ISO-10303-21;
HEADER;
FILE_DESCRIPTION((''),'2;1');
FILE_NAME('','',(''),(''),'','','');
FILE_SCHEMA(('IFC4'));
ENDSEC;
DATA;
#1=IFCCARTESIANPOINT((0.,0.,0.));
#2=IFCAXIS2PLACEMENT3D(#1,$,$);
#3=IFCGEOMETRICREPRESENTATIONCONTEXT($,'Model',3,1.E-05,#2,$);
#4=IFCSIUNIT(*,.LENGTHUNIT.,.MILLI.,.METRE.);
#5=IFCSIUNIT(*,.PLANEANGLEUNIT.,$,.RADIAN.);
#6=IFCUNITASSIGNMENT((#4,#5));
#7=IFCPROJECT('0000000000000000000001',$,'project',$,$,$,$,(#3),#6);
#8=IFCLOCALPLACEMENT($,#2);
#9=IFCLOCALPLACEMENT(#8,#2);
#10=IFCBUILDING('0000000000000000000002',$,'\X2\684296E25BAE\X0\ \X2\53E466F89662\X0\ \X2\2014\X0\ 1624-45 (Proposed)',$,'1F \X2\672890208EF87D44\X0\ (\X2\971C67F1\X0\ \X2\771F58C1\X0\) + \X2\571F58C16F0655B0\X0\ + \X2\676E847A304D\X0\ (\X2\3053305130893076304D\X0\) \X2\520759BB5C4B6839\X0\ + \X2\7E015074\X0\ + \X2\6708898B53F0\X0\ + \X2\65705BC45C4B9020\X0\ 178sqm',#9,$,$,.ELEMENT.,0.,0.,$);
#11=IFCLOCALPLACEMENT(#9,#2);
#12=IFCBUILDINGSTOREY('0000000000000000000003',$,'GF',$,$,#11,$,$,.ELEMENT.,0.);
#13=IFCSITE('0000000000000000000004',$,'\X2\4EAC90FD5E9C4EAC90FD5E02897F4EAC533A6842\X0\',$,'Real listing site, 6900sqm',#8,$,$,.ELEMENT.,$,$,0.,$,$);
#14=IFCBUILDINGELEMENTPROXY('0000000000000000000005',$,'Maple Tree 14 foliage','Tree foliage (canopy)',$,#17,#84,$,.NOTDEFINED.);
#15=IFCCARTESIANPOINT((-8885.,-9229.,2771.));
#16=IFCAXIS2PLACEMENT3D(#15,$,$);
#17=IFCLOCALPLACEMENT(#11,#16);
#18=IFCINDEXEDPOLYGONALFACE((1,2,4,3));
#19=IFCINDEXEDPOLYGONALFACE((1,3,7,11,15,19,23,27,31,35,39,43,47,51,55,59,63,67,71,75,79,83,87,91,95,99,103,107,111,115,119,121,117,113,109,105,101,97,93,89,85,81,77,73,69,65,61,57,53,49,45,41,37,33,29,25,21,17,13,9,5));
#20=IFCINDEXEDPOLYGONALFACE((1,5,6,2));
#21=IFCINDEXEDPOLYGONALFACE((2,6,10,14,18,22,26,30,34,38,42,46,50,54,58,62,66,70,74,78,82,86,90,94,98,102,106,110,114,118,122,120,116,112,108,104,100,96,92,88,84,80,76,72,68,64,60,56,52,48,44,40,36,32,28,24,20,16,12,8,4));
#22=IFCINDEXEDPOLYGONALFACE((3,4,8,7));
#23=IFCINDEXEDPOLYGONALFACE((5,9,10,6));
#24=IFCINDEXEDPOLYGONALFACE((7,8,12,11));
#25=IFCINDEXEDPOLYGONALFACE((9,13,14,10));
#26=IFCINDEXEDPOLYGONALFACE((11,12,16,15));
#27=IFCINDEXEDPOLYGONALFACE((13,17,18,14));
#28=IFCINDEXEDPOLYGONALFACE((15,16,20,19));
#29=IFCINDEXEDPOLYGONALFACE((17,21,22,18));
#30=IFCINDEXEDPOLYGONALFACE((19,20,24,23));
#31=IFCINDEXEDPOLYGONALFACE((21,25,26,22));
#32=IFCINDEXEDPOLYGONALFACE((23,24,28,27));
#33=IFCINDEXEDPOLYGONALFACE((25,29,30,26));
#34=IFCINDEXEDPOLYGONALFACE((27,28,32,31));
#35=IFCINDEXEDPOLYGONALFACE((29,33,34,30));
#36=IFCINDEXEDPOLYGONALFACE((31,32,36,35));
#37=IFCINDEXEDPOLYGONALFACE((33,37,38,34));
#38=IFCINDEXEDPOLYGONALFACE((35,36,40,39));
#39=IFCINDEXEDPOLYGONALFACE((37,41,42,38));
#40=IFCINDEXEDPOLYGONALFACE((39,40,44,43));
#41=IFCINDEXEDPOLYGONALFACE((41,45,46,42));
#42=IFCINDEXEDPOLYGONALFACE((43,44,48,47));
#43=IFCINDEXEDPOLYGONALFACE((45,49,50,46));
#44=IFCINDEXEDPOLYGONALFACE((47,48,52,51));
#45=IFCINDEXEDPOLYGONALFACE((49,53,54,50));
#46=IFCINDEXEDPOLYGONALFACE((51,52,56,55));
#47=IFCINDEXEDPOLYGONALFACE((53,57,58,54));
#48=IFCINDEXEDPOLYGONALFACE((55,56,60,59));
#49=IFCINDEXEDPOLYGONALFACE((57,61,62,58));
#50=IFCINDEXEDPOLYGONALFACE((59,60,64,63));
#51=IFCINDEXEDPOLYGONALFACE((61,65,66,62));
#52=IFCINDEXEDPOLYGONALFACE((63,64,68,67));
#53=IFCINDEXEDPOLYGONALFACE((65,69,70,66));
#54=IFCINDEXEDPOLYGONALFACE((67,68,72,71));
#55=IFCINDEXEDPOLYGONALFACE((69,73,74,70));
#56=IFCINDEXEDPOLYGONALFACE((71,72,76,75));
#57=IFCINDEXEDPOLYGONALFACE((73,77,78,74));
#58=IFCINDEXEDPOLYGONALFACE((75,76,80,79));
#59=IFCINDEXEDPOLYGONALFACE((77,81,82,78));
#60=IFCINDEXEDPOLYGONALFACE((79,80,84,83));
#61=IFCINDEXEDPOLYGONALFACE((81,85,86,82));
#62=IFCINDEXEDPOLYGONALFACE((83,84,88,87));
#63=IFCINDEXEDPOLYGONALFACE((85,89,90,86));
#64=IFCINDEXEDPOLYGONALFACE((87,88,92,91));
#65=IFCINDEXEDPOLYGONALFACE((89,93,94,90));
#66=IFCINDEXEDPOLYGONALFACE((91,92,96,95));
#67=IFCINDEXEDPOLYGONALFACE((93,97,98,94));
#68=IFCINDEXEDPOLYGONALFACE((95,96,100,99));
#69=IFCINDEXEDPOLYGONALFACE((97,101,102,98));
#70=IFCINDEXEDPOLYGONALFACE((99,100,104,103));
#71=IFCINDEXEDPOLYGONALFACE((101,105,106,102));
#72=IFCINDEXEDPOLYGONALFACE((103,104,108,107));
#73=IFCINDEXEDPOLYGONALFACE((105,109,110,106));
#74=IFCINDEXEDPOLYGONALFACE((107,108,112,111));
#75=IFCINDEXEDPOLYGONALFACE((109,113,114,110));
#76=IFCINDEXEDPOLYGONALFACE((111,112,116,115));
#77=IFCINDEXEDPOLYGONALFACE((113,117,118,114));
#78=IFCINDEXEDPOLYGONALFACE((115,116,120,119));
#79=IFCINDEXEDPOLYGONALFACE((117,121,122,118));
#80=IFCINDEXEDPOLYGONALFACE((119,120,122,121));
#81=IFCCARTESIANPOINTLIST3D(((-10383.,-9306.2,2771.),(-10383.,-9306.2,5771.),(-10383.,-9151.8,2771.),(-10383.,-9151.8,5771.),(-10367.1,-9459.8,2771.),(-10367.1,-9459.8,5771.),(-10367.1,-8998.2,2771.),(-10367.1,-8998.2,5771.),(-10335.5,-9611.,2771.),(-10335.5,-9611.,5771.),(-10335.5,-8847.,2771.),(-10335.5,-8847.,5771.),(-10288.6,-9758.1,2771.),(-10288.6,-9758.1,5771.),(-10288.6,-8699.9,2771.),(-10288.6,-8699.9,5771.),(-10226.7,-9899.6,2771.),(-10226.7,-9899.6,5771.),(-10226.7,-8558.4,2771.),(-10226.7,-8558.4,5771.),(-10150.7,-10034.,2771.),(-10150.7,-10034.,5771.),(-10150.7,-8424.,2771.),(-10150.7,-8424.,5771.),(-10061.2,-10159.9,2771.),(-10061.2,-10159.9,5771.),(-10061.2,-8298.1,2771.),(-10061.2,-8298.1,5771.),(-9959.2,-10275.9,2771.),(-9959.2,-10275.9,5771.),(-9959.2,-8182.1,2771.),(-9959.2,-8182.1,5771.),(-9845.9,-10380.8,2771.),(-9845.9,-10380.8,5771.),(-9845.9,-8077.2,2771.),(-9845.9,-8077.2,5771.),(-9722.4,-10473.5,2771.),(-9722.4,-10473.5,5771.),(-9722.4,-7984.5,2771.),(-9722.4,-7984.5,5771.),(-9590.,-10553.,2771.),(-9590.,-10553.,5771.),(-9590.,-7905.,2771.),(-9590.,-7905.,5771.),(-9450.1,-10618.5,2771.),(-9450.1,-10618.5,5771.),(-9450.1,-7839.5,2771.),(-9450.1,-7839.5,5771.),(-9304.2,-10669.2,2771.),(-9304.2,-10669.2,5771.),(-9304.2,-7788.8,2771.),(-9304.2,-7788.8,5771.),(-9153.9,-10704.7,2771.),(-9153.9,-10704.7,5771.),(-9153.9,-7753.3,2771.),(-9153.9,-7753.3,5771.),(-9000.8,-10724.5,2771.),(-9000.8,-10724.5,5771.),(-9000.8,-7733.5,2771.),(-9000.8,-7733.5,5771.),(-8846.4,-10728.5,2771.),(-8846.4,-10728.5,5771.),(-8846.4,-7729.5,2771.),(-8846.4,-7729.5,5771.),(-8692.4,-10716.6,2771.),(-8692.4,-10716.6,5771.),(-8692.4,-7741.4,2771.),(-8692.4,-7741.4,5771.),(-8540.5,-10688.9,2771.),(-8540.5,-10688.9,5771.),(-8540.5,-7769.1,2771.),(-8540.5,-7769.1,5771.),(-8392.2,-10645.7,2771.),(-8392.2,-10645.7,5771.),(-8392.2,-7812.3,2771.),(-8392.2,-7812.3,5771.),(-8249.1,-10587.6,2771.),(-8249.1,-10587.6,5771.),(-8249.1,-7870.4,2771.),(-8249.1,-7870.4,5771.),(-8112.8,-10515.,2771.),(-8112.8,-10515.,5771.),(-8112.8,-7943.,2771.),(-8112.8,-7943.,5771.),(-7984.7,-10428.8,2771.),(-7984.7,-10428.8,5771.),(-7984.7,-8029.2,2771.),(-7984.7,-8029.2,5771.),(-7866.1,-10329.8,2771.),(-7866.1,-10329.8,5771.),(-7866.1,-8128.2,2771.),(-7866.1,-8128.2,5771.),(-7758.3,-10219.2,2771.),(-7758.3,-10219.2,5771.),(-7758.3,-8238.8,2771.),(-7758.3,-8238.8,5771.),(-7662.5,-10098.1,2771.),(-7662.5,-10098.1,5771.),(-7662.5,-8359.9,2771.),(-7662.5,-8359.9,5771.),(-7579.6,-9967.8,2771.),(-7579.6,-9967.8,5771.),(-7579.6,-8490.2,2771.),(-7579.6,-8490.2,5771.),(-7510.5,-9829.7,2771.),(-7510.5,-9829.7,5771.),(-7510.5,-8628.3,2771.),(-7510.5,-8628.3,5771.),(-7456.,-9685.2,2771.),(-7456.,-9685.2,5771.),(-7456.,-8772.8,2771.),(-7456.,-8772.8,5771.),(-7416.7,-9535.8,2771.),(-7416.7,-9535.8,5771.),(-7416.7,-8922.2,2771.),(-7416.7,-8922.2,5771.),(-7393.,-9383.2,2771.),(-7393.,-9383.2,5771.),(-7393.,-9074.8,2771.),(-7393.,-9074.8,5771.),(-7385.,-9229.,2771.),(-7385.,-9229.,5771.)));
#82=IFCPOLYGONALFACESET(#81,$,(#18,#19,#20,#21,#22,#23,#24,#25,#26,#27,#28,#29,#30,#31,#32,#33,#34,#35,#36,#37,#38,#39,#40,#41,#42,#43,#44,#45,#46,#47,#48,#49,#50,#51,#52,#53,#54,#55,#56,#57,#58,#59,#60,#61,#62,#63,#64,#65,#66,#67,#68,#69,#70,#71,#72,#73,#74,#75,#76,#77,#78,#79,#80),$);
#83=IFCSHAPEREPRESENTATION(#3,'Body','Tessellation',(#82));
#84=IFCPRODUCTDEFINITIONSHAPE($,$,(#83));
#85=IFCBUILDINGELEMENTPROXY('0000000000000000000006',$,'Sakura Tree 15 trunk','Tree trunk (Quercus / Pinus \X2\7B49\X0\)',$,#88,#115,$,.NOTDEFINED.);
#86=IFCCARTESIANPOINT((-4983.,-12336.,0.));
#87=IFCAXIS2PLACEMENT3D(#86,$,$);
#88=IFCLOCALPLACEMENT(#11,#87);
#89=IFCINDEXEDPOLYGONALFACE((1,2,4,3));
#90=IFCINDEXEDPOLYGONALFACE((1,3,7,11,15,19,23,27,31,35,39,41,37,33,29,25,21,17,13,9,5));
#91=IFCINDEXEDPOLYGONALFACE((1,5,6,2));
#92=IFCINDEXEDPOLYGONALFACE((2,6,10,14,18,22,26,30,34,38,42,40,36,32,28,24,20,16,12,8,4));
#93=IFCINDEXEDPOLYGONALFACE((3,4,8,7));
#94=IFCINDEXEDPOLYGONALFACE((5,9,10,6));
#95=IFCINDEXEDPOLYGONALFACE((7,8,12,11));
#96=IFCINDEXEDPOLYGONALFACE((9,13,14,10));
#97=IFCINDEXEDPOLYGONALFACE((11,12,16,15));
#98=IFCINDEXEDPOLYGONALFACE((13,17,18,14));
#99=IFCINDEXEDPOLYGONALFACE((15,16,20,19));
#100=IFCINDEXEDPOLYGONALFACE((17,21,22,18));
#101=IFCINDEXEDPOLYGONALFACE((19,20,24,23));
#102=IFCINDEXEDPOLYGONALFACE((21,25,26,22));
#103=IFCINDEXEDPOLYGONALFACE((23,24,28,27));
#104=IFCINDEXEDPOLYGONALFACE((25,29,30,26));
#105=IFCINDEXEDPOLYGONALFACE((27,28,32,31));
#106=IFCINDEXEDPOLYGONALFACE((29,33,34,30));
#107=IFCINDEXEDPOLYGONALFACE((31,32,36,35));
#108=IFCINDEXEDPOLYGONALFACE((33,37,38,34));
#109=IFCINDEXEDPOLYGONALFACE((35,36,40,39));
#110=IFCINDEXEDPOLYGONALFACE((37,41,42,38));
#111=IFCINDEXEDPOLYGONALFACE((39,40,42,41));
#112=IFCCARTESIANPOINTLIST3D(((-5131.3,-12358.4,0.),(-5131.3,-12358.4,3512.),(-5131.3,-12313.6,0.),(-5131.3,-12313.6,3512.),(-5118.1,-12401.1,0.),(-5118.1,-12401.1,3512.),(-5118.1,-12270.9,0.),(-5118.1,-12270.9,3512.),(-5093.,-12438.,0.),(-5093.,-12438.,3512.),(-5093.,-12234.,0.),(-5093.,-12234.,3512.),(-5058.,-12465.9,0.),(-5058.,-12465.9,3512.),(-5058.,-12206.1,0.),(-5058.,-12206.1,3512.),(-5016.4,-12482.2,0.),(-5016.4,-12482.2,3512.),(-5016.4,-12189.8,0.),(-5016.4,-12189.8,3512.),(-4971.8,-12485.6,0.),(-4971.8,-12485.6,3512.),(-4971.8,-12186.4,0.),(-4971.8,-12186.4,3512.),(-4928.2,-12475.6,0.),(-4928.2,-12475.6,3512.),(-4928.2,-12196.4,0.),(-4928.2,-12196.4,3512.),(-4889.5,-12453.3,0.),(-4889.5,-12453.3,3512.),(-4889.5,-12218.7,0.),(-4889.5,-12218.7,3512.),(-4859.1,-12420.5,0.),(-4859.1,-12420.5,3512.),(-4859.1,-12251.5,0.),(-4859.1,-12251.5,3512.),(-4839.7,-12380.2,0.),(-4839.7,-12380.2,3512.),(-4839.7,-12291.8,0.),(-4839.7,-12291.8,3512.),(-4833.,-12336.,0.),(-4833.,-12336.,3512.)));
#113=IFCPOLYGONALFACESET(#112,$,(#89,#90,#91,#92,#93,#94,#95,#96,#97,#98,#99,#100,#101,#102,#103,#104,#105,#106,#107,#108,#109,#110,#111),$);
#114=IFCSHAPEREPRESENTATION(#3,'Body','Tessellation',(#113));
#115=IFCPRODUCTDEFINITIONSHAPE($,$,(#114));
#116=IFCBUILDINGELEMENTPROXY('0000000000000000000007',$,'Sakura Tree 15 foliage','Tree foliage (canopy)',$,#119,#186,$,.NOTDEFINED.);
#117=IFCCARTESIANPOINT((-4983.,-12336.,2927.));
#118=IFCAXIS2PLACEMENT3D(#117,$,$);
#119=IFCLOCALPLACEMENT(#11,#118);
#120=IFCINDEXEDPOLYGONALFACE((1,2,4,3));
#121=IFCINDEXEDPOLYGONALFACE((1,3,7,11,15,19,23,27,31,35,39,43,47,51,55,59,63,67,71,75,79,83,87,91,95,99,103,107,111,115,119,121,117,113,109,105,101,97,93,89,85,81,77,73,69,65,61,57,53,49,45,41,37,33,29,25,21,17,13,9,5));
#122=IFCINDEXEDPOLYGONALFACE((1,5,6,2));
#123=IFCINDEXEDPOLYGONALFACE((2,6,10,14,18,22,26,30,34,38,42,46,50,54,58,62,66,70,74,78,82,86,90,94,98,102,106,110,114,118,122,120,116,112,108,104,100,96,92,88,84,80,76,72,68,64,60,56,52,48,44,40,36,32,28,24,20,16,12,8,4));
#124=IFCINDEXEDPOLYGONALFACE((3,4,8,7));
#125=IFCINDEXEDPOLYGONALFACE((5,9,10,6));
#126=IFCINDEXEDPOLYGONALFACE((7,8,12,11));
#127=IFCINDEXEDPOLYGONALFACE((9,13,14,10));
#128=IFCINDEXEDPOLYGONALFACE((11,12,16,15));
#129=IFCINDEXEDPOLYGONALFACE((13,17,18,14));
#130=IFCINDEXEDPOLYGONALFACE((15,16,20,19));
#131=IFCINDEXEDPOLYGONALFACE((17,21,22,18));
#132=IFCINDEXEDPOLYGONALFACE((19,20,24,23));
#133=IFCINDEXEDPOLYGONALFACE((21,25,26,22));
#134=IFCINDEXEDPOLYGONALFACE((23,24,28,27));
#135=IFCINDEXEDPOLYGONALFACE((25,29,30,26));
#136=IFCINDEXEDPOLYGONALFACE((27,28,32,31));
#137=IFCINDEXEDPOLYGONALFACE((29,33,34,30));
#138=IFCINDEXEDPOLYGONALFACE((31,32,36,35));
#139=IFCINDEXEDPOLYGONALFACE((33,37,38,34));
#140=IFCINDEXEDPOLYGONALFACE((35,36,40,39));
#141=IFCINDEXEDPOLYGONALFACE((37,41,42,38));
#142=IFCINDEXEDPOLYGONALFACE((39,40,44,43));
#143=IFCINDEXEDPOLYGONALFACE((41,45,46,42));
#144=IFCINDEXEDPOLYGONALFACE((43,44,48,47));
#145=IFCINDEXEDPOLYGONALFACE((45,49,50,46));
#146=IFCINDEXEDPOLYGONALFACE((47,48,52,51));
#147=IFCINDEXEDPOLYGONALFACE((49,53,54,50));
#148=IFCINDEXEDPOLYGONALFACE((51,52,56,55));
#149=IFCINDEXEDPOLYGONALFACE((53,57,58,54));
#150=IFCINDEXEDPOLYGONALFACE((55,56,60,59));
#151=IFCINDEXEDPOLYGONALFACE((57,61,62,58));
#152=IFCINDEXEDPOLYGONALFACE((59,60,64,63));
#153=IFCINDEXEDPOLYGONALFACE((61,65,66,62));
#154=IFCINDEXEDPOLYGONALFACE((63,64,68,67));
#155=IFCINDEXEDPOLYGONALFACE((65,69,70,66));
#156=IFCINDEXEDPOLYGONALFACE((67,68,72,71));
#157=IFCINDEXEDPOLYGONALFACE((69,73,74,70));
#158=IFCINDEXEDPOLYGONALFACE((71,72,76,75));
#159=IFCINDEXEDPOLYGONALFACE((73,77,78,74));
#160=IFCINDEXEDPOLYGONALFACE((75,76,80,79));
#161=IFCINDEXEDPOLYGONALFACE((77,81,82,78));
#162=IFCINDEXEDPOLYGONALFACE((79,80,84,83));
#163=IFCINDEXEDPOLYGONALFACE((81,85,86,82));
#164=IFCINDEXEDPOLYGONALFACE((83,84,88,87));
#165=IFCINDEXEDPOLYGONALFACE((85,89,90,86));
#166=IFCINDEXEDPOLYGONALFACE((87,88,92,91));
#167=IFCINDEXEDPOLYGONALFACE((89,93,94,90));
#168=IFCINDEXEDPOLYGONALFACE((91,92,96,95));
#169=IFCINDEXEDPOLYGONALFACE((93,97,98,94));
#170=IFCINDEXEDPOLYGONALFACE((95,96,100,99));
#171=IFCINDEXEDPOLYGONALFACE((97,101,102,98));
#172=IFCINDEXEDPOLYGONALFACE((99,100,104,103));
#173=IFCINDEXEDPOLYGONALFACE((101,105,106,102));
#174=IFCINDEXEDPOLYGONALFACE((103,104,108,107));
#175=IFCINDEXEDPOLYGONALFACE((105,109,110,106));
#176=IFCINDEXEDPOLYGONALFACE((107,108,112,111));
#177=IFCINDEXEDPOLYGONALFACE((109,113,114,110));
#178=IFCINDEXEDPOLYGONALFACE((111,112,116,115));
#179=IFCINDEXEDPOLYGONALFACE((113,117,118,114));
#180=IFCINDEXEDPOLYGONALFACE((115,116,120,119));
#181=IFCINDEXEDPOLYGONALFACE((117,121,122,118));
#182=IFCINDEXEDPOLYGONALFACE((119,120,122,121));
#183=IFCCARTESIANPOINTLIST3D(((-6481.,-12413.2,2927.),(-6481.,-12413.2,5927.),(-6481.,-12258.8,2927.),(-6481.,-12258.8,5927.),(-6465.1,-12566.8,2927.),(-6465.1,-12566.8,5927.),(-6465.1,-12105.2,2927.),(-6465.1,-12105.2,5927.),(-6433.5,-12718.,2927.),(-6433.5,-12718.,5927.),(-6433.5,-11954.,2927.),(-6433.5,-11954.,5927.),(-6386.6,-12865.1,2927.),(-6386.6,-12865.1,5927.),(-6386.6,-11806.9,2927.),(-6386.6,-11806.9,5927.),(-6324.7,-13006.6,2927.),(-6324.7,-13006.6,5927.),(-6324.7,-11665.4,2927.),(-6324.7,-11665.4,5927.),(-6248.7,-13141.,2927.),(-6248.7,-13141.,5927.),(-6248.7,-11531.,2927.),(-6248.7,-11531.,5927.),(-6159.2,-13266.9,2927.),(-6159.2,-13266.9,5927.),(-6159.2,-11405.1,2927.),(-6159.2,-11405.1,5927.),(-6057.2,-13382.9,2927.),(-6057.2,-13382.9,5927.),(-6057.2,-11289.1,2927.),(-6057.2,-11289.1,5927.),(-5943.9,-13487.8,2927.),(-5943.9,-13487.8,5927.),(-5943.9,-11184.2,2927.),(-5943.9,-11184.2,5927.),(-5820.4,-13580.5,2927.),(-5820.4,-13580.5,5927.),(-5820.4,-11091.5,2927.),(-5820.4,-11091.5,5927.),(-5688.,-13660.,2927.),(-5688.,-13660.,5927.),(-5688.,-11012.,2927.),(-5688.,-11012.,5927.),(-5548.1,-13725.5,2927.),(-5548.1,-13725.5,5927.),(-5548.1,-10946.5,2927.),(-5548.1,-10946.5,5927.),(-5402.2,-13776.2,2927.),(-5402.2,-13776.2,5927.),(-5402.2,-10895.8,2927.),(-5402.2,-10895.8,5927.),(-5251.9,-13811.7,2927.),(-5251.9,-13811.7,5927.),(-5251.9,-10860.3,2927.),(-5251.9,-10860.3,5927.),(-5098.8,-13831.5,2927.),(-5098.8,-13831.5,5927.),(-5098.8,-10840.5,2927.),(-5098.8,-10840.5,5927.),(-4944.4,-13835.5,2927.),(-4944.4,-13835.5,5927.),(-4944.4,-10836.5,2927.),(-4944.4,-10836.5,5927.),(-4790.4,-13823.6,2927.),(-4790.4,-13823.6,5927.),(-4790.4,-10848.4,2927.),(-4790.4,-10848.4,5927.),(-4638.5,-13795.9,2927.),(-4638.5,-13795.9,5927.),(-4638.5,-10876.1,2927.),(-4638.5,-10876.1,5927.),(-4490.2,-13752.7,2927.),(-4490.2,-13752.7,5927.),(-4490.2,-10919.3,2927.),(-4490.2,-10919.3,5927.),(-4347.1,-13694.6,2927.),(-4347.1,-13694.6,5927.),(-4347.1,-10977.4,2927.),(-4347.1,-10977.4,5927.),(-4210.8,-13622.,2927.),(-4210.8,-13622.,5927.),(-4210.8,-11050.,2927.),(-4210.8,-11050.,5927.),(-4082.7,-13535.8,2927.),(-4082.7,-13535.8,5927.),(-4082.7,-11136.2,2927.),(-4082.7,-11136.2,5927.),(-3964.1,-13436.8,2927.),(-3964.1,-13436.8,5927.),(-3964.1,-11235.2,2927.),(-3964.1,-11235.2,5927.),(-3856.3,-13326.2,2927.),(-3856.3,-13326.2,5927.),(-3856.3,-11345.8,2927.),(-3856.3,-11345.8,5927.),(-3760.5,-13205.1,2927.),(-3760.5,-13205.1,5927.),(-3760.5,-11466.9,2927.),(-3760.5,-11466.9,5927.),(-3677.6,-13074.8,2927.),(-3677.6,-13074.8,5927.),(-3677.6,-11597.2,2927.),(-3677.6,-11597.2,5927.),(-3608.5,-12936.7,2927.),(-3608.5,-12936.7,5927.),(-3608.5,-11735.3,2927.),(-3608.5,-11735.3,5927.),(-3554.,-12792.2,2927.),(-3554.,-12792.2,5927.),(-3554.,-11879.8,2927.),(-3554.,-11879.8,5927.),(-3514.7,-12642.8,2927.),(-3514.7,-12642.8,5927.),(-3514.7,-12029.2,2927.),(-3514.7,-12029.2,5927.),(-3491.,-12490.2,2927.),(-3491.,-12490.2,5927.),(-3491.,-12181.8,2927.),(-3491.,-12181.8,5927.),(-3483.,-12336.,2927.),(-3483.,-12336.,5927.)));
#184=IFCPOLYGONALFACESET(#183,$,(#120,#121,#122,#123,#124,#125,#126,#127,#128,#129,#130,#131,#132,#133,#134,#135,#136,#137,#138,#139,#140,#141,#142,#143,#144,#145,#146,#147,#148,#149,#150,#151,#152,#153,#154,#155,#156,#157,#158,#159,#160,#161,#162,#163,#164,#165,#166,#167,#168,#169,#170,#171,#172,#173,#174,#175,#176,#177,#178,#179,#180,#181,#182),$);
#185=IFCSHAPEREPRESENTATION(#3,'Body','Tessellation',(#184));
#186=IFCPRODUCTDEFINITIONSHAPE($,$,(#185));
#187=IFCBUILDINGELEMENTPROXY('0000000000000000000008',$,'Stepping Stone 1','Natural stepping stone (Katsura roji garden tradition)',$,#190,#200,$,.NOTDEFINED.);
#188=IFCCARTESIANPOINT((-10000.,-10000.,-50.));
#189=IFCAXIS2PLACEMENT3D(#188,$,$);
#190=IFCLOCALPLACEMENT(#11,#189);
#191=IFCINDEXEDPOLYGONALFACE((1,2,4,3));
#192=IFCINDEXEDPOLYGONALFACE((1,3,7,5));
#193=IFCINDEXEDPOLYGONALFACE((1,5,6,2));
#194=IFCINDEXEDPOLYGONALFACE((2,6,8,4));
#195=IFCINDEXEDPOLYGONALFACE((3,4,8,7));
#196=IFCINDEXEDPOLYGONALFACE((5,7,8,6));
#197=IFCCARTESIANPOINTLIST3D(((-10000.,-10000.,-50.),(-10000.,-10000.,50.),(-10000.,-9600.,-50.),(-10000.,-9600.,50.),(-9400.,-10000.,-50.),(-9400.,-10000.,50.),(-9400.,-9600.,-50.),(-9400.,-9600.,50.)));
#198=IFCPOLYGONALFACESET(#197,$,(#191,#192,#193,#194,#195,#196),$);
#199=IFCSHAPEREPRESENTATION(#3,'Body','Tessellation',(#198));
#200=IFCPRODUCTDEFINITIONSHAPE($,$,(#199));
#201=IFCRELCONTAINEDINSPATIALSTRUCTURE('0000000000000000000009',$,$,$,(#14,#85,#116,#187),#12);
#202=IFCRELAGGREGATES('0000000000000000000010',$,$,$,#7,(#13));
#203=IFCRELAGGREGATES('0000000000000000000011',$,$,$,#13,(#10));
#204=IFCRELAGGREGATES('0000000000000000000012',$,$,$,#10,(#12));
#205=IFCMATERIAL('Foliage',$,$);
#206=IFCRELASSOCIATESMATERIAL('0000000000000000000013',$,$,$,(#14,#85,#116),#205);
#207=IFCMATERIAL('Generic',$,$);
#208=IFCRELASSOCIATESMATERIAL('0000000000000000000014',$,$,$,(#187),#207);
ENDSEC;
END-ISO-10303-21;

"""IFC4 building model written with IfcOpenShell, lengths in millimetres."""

from ifc_helpers import new_model, si_unit, frame, frame_2d, origin, origin_2d, place, context, project, spatial, rectangle, circle, extrude, material, element, save


model = new_model("IFC4")

# Units and contexts
model_context = context("Model", 3, precision=1e-05, world=origin())
ifc_project = project(units=[si_unit("LENGTHUNIT", "METRE", prefix="MILLI"), si_unit("PLANEANGLEUNIT", "RADIAN")], contexts=[model_context])

# Site, building, storey
site_placement = place(None, origin())
site = spatial("IfcSite", under=ifc_project, at=site_placement, Name="京都府京都市西京区桂", ObjectType="Real listing site, 6900sqm", CompositionType="ELEMENT", RefElevation=0.0)
building_placement = place(site_placement, origin())
building = spatial("IfcBuilding", under=site, at=building_placement, Name="桂離宮 古書院 — 1624-45 (Proposed)", ObjectType="1F 木造軸組 (霜柱 真壁) + 土壁漆喰 + 杮葺き (こけらぶき) 切妻屋根 + 縁側 + 月見台 + 数寄屋造 178sqm", CompositionType="ELEMENT", ElevationOfRefHeight=0.0, ElevationOfTerrain=0.0)
storey_placement = place(building_placement, origin())
storey = spatial("IfcBuildingStorey", under=building, at=storey_placement, Name="GF", CompositionType="ELEMENT", Elevation=0.0)

# Shared definitions
ifc_material_1 = material(Name="Generic")

# Building element proxies
ifc_material_2 = material(Name="Foliage")
proxy_1_placement = place(storey_placement, frame((-8885.0, -9229.0, 2771.0)))
element("IfcBuildingElementProxy", 1, at=proxy_1_placement, inside=storey, material=ifc_material_2, Name="Maple Tree 14 foliage", Description="Tree foliage (canopy)", PredefinedType="NOTDEFINED", context=model_context, shape_type="SweptSolid", body=[
    extrude(circle(Radius=1500.0, at=origin_2d()), frame((-8885.0, -9229.0, 2771.0)), (0.0, 0.0, 1.0), 3000.0),
])
proxy_2_placement = place(storey_placement, frame((-4983.0, -12336.0, 0.0)))
element("IfcBuildingElementProxy", 2, at=proxy_2_placement, inside=storey, material=ifc_material_2, Name="Sakura Tree 15 trunk", Description="Tree trunk (Quercus / Pinus 等)", PredefinedType="NOTDEFINED", context=model_context, shape_type="SweptSolid", body=[
    extrude(circle(Radius=150.0, at=origin_2d()), frame((-4983.0, -12336.0, 0.0)), (0.0, 0.0, 1.0), 3512.0),
])
proxy_3_placement = place(storey_placement, frame((-4983.0, -12336.0, 2927.0)))
element("IfcBuildingElementProxy", 3, at=proxy_3_placement, inside=storey, material=ifc_material_2, Name="Sakura Tree 15 foliage", Description="Tree foliage (canopy)", PredefinedType="NOTDEFINED", context=model_context, shape_type="SweptSolid", body=[
    extrude(circle(Radius=1500.0, at=origin_2d()), frame((-4983.0, -12336.0, 2927.0)), (0.0, 0.0, 1.0), 3000.0),
])
proxy_4_placement = place(storey_placement, frame((-10000.0, -10000.0, -50.0)))
element("IfcBuildingElementProxy", 4, at=proxy_4_placement, inside=storey, material=ifc_material_1, Name="Stepping Stone 1", Description="Natural stepping stone (Katsura roji garden tradition)", PredefinedType="NOTDEFINED", context=model_context, shape_type="SweptSolid", body=[
    extrude(rectangle(XDim=600.0, YDim=400.0, at=frame_2d((300.0, 200.0))), frame((-10000.0, -10000.0, -50.0)), (0.0, 0.0, 1.0), 100.0),
])

save(model, "model.ifc")
